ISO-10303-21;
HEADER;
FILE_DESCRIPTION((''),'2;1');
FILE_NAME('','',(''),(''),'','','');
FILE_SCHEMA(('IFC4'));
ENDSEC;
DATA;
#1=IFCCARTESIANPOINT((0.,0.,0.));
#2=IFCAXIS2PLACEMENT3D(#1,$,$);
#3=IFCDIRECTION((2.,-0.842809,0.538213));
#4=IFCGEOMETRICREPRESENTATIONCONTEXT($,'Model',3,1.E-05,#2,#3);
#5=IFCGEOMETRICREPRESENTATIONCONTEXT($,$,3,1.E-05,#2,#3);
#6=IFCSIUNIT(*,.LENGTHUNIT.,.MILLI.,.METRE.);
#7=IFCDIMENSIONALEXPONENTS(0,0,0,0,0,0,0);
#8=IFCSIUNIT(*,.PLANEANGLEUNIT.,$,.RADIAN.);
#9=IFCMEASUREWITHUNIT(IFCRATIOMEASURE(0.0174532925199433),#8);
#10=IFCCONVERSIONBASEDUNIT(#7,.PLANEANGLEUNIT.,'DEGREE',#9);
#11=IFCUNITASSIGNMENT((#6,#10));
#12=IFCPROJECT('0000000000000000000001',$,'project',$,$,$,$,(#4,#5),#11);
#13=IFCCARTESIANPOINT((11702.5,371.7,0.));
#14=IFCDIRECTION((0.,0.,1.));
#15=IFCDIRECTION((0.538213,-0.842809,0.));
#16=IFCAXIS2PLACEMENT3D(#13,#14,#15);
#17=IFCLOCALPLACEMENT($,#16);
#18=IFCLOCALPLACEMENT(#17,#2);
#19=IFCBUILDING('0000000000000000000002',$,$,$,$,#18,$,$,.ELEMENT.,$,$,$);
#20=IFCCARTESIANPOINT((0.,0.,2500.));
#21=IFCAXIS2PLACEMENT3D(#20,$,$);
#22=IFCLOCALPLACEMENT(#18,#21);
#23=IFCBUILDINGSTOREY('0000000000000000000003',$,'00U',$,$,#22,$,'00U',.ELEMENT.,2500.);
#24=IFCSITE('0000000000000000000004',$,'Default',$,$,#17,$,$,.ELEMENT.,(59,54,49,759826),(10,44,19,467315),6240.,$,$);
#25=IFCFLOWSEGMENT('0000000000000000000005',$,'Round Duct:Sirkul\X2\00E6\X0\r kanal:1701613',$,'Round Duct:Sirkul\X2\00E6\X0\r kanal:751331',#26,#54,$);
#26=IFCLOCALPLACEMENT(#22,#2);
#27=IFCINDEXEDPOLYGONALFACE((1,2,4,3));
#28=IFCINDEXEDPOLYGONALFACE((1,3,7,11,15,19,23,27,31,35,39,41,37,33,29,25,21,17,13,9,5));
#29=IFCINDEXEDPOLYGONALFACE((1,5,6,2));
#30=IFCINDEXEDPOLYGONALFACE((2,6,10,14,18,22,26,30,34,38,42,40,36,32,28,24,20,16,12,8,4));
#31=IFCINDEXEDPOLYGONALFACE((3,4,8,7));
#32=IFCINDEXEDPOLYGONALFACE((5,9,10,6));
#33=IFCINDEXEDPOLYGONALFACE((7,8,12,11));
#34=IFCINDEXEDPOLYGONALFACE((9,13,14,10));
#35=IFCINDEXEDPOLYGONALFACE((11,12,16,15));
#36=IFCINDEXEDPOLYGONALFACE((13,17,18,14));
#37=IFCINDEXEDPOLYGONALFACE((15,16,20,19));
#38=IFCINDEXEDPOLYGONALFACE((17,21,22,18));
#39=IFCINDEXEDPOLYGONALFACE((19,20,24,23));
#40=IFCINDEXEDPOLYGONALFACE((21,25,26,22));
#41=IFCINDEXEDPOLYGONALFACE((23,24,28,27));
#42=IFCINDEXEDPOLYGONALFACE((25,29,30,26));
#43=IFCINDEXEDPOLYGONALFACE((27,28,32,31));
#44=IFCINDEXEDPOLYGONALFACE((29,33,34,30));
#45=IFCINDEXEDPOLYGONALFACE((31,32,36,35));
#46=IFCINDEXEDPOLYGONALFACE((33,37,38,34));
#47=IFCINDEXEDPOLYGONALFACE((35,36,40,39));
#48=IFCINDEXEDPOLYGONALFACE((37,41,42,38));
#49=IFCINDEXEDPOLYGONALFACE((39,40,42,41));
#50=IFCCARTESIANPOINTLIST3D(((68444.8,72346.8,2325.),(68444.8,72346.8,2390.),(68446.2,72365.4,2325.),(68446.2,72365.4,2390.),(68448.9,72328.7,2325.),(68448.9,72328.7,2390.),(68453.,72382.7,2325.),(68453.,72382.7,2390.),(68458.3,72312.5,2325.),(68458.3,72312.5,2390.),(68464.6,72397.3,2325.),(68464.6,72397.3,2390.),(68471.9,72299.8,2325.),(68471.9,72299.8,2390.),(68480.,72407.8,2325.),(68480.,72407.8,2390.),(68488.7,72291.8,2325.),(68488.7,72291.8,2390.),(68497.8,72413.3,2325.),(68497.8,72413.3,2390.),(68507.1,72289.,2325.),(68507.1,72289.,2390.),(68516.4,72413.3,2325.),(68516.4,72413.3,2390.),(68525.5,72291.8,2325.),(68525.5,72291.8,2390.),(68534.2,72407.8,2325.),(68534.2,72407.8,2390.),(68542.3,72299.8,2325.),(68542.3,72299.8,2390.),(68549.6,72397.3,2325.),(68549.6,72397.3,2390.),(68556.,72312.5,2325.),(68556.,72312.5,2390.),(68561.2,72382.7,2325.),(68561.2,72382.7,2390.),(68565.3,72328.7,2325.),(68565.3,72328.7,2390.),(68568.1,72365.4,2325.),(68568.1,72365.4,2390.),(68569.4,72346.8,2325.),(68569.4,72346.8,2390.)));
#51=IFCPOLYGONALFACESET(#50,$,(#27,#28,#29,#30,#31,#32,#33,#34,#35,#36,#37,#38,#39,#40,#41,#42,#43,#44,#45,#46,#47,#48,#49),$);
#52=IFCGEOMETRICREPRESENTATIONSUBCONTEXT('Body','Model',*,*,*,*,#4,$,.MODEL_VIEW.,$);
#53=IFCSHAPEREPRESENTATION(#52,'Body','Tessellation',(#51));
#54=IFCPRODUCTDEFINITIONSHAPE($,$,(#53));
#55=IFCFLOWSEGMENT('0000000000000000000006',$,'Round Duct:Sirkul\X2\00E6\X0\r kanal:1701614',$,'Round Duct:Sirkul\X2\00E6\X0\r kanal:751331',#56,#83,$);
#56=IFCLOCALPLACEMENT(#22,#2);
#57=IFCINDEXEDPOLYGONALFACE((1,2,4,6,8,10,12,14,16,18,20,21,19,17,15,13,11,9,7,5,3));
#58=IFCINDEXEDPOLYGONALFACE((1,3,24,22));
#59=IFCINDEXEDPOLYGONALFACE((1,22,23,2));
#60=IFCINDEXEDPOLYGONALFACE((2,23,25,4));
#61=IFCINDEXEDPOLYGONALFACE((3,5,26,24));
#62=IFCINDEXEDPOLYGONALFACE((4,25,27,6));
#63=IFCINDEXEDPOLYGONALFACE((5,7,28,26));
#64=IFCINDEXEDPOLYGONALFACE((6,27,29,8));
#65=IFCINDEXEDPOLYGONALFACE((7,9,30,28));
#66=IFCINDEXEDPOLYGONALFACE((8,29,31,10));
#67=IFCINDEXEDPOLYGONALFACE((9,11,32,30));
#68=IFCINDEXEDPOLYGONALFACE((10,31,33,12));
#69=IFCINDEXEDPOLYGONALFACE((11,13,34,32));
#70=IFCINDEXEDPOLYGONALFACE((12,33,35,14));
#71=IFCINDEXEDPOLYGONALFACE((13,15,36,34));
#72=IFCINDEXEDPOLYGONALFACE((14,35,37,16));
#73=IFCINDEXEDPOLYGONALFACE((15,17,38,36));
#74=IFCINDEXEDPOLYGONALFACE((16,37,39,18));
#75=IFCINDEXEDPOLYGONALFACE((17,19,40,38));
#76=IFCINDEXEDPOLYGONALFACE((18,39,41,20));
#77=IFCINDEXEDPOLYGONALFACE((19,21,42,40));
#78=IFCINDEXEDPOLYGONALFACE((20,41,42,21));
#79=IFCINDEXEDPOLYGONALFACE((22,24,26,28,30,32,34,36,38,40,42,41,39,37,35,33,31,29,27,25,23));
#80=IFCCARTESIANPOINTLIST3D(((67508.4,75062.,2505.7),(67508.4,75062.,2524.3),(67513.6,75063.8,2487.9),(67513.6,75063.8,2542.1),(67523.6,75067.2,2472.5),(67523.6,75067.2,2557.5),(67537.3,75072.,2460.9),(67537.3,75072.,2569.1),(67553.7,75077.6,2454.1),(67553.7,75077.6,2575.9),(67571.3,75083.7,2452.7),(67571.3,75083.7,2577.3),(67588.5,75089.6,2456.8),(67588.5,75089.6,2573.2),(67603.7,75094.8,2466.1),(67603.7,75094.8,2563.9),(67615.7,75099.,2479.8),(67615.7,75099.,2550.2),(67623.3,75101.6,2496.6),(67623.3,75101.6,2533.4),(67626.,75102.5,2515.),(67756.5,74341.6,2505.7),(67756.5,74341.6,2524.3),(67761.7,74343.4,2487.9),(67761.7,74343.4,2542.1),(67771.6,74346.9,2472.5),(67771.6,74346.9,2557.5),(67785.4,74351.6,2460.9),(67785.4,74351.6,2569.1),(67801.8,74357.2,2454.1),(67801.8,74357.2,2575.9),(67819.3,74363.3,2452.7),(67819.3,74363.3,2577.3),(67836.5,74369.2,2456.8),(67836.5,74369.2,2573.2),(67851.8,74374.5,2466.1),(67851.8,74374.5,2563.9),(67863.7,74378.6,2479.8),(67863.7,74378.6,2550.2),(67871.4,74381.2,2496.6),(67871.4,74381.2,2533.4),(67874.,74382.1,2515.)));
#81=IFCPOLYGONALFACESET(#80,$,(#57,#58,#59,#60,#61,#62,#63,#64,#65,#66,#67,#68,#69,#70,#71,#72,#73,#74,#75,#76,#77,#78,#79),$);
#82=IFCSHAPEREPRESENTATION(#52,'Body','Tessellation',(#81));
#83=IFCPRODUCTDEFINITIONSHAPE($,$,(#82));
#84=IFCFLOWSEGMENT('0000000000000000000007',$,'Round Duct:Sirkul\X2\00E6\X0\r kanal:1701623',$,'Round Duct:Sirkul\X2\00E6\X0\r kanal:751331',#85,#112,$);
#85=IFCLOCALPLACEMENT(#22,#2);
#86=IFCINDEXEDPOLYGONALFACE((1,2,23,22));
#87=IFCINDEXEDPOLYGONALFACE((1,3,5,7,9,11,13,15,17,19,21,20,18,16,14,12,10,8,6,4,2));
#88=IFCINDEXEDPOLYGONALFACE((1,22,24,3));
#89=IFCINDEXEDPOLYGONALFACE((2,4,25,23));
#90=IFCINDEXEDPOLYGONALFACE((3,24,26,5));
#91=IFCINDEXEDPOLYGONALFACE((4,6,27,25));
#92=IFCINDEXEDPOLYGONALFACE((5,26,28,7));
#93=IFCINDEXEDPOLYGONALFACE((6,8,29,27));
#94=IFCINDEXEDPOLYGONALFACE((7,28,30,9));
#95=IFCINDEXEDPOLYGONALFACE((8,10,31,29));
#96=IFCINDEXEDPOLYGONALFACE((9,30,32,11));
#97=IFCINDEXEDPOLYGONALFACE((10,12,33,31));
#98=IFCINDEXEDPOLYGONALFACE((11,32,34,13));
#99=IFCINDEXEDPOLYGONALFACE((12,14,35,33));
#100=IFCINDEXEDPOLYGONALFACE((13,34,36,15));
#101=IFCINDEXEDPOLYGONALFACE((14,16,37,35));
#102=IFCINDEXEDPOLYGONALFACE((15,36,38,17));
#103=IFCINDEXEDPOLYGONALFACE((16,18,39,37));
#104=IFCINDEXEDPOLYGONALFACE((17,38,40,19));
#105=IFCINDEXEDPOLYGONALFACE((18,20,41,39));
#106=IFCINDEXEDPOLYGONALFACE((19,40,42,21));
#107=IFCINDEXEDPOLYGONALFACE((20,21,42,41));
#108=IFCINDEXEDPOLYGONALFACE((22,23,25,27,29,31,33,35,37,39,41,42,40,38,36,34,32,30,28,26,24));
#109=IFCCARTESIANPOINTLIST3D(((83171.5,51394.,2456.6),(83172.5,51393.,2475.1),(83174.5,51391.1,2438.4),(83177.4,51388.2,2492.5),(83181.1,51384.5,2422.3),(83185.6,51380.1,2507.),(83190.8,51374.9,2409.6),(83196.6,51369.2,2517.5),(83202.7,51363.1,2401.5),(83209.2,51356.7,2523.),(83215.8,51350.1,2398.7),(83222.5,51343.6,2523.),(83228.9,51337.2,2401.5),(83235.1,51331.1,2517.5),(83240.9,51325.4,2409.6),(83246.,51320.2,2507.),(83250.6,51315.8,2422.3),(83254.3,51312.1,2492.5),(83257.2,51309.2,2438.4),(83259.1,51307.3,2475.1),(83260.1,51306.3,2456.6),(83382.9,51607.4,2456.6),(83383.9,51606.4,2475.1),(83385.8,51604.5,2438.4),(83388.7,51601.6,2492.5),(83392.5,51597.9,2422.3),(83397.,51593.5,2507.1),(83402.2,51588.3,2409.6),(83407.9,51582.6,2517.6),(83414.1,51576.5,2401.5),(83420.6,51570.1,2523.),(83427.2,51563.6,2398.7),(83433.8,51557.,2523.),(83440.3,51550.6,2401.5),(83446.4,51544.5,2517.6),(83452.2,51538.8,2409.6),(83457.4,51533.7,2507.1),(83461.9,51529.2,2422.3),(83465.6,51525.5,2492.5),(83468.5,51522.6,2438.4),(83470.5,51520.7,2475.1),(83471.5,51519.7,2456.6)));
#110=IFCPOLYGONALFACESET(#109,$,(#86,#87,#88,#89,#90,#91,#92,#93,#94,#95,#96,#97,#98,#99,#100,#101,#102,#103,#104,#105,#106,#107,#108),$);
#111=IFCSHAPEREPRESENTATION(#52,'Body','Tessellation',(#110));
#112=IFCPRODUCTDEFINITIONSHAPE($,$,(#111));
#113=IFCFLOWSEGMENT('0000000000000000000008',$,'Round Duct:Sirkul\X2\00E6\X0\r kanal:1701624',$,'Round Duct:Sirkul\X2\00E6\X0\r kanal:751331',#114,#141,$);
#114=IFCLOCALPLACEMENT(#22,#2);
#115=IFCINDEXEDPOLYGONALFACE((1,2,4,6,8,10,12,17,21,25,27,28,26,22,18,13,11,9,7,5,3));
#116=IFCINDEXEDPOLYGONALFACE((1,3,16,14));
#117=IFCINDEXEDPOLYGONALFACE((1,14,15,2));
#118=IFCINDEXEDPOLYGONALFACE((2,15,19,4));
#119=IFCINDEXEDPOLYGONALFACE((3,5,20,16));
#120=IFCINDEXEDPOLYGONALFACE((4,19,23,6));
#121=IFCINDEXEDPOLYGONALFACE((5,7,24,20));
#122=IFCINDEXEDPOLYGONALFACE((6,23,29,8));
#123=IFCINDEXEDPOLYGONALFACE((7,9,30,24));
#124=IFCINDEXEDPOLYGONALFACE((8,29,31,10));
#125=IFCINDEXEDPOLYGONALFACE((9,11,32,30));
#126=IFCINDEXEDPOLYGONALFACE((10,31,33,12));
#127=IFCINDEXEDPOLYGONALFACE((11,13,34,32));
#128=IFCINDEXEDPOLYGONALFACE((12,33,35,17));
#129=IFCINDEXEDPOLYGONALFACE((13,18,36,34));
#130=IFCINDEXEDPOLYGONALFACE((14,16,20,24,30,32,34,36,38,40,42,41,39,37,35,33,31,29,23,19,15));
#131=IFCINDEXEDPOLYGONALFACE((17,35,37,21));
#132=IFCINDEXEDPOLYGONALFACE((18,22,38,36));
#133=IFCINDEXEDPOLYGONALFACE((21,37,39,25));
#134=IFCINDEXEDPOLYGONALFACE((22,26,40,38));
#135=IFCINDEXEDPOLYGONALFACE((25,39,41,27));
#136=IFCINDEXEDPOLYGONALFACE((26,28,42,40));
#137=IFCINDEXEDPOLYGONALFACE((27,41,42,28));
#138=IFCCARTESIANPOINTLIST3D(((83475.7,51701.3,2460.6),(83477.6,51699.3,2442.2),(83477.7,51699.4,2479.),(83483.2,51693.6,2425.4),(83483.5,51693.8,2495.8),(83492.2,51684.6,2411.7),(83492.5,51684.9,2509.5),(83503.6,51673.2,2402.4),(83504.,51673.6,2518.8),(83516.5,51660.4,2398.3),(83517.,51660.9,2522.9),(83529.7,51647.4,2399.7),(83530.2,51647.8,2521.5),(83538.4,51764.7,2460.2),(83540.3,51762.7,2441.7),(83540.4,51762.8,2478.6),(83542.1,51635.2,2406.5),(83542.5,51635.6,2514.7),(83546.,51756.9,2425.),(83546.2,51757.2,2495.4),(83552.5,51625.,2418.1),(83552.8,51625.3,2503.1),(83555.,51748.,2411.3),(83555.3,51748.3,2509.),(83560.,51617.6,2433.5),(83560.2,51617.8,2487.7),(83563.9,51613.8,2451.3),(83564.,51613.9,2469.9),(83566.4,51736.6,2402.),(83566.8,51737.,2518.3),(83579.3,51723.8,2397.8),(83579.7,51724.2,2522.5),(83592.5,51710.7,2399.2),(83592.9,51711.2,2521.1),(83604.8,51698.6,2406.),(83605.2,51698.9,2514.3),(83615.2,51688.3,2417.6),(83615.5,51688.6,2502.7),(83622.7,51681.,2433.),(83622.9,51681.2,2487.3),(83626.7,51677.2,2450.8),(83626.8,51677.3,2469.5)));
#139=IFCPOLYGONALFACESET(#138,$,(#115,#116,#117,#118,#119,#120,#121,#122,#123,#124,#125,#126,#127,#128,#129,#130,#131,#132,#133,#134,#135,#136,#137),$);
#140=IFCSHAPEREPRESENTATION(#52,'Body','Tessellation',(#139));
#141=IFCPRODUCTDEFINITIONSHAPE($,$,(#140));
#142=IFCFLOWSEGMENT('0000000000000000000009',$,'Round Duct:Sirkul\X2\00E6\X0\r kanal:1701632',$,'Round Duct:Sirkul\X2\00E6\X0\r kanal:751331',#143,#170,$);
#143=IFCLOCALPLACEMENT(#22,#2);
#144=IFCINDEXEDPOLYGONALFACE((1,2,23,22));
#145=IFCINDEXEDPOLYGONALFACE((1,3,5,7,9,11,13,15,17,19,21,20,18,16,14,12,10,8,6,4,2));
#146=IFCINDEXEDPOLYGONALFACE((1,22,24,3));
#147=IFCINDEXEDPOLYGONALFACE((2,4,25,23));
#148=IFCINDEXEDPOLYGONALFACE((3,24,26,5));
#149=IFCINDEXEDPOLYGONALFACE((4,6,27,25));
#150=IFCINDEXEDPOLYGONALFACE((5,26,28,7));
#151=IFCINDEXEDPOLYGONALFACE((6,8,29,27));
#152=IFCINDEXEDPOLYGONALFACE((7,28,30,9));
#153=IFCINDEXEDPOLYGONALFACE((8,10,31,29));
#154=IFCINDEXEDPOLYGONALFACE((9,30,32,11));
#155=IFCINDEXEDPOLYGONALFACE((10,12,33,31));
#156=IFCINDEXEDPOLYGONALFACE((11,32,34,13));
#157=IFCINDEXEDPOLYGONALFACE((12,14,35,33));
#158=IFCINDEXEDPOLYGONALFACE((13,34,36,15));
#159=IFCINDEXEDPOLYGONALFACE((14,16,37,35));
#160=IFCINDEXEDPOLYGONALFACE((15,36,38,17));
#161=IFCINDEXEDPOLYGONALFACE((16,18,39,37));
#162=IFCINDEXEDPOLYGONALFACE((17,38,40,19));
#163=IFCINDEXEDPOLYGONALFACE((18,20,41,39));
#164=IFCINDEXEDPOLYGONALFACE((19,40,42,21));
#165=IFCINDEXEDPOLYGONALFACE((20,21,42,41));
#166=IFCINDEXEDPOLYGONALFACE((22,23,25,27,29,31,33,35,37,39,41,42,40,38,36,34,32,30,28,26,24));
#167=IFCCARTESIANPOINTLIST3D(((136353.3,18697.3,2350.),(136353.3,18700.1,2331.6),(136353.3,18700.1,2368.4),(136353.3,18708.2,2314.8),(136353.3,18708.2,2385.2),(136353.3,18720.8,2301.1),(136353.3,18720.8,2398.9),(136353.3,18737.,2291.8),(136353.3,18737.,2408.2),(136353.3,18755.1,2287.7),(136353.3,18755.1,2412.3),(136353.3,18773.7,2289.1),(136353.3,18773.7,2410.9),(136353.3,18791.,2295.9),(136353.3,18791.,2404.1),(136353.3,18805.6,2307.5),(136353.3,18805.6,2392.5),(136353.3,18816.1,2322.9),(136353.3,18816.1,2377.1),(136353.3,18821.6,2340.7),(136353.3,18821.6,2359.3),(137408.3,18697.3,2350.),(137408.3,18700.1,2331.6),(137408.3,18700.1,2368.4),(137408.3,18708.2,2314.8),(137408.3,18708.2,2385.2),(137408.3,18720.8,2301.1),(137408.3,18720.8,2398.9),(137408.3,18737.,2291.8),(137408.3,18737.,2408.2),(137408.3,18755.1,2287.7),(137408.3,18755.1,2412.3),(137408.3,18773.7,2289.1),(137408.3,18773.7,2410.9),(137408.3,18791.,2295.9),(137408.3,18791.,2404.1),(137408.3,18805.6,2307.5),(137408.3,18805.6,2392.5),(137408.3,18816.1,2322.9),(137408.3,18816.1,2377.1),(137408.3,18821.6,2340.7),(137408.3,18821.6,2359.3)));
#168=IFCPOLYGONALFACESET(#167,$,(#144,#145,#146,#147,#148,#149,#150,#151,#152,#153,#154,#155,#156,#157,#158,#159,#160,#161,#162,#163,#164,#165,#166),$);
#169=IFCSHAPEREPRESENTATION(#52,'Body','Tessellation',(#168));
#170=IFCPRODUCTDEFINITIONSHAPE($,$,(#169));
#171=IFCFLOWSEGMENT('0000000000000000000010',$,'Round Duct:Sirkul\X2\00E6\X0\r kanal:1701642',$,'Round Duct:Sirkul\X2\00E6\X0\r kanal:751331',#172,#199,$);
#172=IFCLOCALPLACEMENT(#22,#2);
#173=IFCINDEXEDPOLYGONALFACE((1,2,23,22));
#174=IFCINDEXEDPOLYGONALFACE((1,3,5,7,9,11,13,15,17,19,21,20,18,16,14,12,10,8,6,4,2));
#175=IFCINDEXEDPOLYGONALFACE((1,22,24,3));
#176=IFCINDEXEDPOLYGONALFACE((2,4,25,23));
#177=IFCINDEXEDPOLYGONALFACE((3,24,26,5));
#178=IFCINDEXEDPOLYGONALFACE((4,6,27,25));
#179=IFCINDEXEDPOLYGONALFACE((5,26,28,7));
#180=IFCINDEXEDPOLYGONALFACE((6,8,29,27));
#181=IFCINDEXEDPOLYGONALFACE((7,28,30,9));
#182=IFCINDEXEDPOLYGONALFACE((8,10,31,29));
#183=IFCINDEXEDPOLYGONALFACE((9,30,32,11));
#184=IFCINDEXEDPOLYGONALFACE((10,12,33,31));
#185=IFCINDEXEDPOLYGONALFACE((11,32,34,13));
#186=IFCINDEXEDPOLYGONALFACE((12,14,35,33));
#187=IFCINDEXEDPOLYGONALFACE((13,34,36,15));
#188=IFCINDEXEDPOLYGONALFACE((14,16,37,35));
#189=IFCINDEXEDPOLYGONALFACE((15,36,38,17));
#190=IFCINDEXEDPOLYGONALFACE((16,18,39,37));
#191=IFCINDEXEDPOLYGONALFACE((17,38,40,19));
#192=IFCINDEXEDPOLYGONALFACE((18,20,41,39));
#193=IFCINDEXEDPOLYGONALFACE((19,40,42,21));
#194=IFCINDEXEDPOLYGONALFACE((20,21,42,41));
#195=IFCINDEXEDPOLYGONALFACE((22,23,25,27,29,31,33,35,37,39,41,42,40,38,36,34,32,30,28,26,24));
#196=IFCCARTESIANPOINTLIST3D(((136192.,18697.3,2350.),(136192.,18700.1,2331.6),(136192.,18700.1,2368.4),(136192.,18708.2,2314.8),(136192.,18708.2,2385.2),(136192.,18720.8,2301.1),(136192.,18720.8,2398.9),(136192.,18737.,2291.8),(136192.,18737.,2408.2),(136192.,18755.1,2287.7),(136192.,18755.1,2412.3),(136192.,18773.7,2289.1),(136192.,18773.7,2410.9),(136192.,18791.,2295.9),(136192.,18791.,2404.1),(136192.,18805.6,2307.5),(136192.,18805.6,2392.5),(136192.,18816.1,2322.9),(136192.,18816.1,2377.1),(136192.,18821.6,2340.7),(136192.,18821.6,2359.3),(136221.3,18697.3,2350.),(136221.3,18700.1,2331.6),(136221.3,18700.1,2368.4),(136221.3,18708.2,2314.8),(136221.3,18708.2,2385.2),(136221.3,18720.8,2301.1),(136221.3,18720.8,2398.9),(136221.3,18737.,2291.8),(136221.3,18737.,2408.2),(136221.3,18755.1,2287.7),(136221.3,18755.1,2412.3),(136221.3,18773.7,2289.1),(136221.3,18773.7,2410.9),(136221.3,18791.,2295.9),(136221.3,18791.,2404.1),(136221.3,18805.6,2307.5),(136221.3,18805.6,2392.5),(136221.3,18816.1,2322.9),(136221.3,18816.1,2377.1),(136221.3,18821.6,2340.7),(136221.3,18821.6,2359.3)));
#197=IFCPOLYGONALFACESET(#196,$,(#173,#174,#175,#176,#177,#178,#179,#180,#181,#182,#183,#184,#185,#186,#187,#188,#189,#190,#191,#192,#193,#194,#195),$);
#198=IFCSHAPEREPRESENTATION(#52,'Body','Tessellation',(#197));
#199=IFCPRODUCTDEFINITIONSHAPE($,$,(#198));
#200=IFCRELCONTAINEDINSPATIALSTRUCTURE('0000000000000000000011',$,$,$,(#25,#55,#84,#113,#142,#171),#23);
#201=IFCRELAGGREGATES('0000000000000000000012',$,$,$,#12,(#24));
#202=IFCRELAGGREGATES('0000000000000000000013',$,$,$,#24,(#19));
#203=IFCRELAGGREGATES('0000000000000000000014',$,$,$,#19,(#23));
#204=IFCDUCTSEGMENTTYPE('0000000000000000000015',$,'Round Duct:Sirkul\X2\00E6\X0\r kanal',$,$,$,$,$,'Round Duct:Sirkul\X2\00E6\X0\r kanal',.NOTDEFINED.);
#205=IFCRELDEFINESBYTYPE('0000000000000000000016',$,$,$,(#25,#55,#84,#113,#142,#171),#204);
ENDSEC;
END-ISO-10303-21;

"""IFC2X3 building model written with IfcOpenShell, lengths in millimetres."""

from ifc_helpers import new_model, entity, si_unit, converted_unit, direction, frame, frame_2d, origin, origin_2d_with_axis, place, context, subcontext, project, spatial, circle, extrude, type_object, element, save


model = new_model("IFC2X3")

# Units and contexts
model_context = context("Model", 3, precision=1e-05, world=origin(), true_north=direction((2.0, -0.842809, 0.538213)))
context_of_model = context(None, 3, precision=1e-05, world=origin(), true_north=direction((2.0, -0.842809, 0.538213)))
body_context = subcontext(model_context, "Body", "Model", "MODEL_VIEW")
ifc_project = project(units=[si_unit("LENGTHUNIT", "METRE", prefix="MILLI"), converted_unit("PLANEANGLEUNIT", "DEGREE", entity("IfcRatioMeasure", 0.0174532925199433), si_unit("PLANEANGLEUNIT", "RADIAN"), dimensions=[0, 0, 0, 0, 0, 0, 0])], contexts=[model_context, context_of_model])

# Site, building, storey
site_placement = place(None, frame((11702.5, 371.7, 0.0), z_axis=(0.0, 0.0, 1.0), x_axis=(0.538213, -0.842809, 0.0)))
site = spatial("IfcSite", under=ifc_project, at=site_placement, Name="Default", CompositionType="ELEMENT", RefLatitude=(59, 54, 49, 759826), RefLongitude=(10, 44, 19, 467315), RefElevation=6240.0)
building_placement = place(site_placement, origin())
building = spatial("IfcBuilding", under=site, at=building_placement, CompositionType="ELEMENT")
storey_placement = place(building_placement, frame((0.0, 0.0, 2500.0)))
storey = spatial("IfcBuildingStorey", under=building, at=storey_placement, Name="00U", LongName="00U", CompositionType="ELEMENT", Elevation=2500.0)

# Flow segments
duct_segment_type = type_object("IfcDuctSegmentType", Name="Round Duct:Sirkulær kanal", ElementType="Round Duct:Sirkulær kanal", PredefinedType="NOTDEFINED")
flow_segment_1_placement = place(storey_placement, origin())
element("IfcFlowSegment", 1, at=flow_segment_1_placement, inside=storey, type_object=duct_segment_type, Name="Round Duct:Sirkulær kanal:1701613", ObjectType="Round Duct:Sirkulær kanal:751331", context=body_context, shape_type="SweptSolid", body=[
    extrude(circle(Radius=62.5, at=frame_2d((0.0, 0.0), x_axis=(1.0, 0.0))), frame((68507.1, 72351.5, 2325.0), z_axis=(0.0, 0.0, 1.0), x_axis=(0.0, -1.0, 0.0)), (0.0, 0.0, 1.0), 65.0),
])
flow_segment_2_placement = place(storey_placement, origin())
element("IfcFlowSegment", 2, at=flow_segment_2_placement, inside=storey, type_object=duct_segment_type, Name="Round Duct:Sirkulær kanal:1701614", ObjectType="Round Duct:Sirkulær kanal:751331", context=body_context, shape_type="SweptSolid", body=[
    extrude(circle(Radius=62.5, at=origin_2d_with_axis()), frame((67814.9, 74361.8, 2515.0), z_axis=(-0.325568, 0.945519, 0.0), x_axis=(0.945519, 0.325568, 0.0)), (0.0, 0.0, 1.0), 761.9),
])
flow_segment_3_placement = place(storey_placement, origin())
element("IfcFlowSegment", 3, at=flow_segment_3_placement, inside=storey, type_object=duct_segment_type, Name="Round Duct:Sirkulær kanal:1701623", ObjectType="Round Duct:Sirkulær kanal:751331", context=body_context, shape_type="SweptSolid", body=[
    extrude(circle(Radius=62.5, at=origin_2d_with_axis()), frame((83215.8, 51350.1, 2461.2), z_axis=(0.703643, 0.710554, 0.000026), x_axis=(0.000018, 0.000018, -1.0)), (0.0, 0.0, 1.0), 300.4),
])
flow_segment_4_placement = place(storey_placement, origin())
element("IfcFlowSegment", 4, at=flow_segment_4_placement, inside=storey, type_object=duct_segment_type, Name="Round Duct:Sirkulær kanal:1701624", ObjectType="Round Duct:Sirkulær kanal:751331", context=body_context, shape_type="SweptSolid", body=[
    extrude(circle(Radius=62.5, at=origin_2d_with_axis()), frame((83520.1, 51657.4, 2460.6), z_axis=(0.703634, 0.710545, -0.004887), x_axis=(-0.710554, 0.703643, 0.0)), (0.0, 0.0, 1.0), 89.2),
])
flow_segment_5_placement = place(storey_placement, origin())
element("IfcFlowSegment", 5, at=flow_segment_5_placement, inside=storey, type_object=duct_segment_type, Name="Round Duct:Sirkulær kanal:1701632", ObjectType="Round Duct:Sirkulær kanal:751331", context=body_context, shape_type="SweptSolid", body=[
    extrude(circle(Radius=62.5, at=origin_2d_with_axis()), frame((136353.3, 18759.8, 2350.0), z_axis=(1.0, -0.000005, 0.0), x_axis=(-0.000005, -1.0, 0.0)), (0.0, 0.0, 1.0), 1055.0),
])
flow_segment_6_placement = place(storey_placement, origin())
element("IfcFlowSegment", 6, at=flow_segment_6_placement, inside=storey, type_object=duct_segment_type, Name="Round Duct:Sirkulær kanal:1701642", ObjectType="Round Duct:Sirkulær kanal:751331", context=body_context, shape_type="SweptSolid", body=[
    extrude(circle(Radius=62.5, at=frame_2d((0.0, 0.0), x_axis=(1.0, 0.0))), frame((136192.0, 18759.8, 2350.0), z_axis=(1.0, 0.000001, 0.0), x_axis=(0.000001, -1.0, 0.0)), (0.0, 0.0, 1.0), 29.3),
])

save(model, "model.ifc")
